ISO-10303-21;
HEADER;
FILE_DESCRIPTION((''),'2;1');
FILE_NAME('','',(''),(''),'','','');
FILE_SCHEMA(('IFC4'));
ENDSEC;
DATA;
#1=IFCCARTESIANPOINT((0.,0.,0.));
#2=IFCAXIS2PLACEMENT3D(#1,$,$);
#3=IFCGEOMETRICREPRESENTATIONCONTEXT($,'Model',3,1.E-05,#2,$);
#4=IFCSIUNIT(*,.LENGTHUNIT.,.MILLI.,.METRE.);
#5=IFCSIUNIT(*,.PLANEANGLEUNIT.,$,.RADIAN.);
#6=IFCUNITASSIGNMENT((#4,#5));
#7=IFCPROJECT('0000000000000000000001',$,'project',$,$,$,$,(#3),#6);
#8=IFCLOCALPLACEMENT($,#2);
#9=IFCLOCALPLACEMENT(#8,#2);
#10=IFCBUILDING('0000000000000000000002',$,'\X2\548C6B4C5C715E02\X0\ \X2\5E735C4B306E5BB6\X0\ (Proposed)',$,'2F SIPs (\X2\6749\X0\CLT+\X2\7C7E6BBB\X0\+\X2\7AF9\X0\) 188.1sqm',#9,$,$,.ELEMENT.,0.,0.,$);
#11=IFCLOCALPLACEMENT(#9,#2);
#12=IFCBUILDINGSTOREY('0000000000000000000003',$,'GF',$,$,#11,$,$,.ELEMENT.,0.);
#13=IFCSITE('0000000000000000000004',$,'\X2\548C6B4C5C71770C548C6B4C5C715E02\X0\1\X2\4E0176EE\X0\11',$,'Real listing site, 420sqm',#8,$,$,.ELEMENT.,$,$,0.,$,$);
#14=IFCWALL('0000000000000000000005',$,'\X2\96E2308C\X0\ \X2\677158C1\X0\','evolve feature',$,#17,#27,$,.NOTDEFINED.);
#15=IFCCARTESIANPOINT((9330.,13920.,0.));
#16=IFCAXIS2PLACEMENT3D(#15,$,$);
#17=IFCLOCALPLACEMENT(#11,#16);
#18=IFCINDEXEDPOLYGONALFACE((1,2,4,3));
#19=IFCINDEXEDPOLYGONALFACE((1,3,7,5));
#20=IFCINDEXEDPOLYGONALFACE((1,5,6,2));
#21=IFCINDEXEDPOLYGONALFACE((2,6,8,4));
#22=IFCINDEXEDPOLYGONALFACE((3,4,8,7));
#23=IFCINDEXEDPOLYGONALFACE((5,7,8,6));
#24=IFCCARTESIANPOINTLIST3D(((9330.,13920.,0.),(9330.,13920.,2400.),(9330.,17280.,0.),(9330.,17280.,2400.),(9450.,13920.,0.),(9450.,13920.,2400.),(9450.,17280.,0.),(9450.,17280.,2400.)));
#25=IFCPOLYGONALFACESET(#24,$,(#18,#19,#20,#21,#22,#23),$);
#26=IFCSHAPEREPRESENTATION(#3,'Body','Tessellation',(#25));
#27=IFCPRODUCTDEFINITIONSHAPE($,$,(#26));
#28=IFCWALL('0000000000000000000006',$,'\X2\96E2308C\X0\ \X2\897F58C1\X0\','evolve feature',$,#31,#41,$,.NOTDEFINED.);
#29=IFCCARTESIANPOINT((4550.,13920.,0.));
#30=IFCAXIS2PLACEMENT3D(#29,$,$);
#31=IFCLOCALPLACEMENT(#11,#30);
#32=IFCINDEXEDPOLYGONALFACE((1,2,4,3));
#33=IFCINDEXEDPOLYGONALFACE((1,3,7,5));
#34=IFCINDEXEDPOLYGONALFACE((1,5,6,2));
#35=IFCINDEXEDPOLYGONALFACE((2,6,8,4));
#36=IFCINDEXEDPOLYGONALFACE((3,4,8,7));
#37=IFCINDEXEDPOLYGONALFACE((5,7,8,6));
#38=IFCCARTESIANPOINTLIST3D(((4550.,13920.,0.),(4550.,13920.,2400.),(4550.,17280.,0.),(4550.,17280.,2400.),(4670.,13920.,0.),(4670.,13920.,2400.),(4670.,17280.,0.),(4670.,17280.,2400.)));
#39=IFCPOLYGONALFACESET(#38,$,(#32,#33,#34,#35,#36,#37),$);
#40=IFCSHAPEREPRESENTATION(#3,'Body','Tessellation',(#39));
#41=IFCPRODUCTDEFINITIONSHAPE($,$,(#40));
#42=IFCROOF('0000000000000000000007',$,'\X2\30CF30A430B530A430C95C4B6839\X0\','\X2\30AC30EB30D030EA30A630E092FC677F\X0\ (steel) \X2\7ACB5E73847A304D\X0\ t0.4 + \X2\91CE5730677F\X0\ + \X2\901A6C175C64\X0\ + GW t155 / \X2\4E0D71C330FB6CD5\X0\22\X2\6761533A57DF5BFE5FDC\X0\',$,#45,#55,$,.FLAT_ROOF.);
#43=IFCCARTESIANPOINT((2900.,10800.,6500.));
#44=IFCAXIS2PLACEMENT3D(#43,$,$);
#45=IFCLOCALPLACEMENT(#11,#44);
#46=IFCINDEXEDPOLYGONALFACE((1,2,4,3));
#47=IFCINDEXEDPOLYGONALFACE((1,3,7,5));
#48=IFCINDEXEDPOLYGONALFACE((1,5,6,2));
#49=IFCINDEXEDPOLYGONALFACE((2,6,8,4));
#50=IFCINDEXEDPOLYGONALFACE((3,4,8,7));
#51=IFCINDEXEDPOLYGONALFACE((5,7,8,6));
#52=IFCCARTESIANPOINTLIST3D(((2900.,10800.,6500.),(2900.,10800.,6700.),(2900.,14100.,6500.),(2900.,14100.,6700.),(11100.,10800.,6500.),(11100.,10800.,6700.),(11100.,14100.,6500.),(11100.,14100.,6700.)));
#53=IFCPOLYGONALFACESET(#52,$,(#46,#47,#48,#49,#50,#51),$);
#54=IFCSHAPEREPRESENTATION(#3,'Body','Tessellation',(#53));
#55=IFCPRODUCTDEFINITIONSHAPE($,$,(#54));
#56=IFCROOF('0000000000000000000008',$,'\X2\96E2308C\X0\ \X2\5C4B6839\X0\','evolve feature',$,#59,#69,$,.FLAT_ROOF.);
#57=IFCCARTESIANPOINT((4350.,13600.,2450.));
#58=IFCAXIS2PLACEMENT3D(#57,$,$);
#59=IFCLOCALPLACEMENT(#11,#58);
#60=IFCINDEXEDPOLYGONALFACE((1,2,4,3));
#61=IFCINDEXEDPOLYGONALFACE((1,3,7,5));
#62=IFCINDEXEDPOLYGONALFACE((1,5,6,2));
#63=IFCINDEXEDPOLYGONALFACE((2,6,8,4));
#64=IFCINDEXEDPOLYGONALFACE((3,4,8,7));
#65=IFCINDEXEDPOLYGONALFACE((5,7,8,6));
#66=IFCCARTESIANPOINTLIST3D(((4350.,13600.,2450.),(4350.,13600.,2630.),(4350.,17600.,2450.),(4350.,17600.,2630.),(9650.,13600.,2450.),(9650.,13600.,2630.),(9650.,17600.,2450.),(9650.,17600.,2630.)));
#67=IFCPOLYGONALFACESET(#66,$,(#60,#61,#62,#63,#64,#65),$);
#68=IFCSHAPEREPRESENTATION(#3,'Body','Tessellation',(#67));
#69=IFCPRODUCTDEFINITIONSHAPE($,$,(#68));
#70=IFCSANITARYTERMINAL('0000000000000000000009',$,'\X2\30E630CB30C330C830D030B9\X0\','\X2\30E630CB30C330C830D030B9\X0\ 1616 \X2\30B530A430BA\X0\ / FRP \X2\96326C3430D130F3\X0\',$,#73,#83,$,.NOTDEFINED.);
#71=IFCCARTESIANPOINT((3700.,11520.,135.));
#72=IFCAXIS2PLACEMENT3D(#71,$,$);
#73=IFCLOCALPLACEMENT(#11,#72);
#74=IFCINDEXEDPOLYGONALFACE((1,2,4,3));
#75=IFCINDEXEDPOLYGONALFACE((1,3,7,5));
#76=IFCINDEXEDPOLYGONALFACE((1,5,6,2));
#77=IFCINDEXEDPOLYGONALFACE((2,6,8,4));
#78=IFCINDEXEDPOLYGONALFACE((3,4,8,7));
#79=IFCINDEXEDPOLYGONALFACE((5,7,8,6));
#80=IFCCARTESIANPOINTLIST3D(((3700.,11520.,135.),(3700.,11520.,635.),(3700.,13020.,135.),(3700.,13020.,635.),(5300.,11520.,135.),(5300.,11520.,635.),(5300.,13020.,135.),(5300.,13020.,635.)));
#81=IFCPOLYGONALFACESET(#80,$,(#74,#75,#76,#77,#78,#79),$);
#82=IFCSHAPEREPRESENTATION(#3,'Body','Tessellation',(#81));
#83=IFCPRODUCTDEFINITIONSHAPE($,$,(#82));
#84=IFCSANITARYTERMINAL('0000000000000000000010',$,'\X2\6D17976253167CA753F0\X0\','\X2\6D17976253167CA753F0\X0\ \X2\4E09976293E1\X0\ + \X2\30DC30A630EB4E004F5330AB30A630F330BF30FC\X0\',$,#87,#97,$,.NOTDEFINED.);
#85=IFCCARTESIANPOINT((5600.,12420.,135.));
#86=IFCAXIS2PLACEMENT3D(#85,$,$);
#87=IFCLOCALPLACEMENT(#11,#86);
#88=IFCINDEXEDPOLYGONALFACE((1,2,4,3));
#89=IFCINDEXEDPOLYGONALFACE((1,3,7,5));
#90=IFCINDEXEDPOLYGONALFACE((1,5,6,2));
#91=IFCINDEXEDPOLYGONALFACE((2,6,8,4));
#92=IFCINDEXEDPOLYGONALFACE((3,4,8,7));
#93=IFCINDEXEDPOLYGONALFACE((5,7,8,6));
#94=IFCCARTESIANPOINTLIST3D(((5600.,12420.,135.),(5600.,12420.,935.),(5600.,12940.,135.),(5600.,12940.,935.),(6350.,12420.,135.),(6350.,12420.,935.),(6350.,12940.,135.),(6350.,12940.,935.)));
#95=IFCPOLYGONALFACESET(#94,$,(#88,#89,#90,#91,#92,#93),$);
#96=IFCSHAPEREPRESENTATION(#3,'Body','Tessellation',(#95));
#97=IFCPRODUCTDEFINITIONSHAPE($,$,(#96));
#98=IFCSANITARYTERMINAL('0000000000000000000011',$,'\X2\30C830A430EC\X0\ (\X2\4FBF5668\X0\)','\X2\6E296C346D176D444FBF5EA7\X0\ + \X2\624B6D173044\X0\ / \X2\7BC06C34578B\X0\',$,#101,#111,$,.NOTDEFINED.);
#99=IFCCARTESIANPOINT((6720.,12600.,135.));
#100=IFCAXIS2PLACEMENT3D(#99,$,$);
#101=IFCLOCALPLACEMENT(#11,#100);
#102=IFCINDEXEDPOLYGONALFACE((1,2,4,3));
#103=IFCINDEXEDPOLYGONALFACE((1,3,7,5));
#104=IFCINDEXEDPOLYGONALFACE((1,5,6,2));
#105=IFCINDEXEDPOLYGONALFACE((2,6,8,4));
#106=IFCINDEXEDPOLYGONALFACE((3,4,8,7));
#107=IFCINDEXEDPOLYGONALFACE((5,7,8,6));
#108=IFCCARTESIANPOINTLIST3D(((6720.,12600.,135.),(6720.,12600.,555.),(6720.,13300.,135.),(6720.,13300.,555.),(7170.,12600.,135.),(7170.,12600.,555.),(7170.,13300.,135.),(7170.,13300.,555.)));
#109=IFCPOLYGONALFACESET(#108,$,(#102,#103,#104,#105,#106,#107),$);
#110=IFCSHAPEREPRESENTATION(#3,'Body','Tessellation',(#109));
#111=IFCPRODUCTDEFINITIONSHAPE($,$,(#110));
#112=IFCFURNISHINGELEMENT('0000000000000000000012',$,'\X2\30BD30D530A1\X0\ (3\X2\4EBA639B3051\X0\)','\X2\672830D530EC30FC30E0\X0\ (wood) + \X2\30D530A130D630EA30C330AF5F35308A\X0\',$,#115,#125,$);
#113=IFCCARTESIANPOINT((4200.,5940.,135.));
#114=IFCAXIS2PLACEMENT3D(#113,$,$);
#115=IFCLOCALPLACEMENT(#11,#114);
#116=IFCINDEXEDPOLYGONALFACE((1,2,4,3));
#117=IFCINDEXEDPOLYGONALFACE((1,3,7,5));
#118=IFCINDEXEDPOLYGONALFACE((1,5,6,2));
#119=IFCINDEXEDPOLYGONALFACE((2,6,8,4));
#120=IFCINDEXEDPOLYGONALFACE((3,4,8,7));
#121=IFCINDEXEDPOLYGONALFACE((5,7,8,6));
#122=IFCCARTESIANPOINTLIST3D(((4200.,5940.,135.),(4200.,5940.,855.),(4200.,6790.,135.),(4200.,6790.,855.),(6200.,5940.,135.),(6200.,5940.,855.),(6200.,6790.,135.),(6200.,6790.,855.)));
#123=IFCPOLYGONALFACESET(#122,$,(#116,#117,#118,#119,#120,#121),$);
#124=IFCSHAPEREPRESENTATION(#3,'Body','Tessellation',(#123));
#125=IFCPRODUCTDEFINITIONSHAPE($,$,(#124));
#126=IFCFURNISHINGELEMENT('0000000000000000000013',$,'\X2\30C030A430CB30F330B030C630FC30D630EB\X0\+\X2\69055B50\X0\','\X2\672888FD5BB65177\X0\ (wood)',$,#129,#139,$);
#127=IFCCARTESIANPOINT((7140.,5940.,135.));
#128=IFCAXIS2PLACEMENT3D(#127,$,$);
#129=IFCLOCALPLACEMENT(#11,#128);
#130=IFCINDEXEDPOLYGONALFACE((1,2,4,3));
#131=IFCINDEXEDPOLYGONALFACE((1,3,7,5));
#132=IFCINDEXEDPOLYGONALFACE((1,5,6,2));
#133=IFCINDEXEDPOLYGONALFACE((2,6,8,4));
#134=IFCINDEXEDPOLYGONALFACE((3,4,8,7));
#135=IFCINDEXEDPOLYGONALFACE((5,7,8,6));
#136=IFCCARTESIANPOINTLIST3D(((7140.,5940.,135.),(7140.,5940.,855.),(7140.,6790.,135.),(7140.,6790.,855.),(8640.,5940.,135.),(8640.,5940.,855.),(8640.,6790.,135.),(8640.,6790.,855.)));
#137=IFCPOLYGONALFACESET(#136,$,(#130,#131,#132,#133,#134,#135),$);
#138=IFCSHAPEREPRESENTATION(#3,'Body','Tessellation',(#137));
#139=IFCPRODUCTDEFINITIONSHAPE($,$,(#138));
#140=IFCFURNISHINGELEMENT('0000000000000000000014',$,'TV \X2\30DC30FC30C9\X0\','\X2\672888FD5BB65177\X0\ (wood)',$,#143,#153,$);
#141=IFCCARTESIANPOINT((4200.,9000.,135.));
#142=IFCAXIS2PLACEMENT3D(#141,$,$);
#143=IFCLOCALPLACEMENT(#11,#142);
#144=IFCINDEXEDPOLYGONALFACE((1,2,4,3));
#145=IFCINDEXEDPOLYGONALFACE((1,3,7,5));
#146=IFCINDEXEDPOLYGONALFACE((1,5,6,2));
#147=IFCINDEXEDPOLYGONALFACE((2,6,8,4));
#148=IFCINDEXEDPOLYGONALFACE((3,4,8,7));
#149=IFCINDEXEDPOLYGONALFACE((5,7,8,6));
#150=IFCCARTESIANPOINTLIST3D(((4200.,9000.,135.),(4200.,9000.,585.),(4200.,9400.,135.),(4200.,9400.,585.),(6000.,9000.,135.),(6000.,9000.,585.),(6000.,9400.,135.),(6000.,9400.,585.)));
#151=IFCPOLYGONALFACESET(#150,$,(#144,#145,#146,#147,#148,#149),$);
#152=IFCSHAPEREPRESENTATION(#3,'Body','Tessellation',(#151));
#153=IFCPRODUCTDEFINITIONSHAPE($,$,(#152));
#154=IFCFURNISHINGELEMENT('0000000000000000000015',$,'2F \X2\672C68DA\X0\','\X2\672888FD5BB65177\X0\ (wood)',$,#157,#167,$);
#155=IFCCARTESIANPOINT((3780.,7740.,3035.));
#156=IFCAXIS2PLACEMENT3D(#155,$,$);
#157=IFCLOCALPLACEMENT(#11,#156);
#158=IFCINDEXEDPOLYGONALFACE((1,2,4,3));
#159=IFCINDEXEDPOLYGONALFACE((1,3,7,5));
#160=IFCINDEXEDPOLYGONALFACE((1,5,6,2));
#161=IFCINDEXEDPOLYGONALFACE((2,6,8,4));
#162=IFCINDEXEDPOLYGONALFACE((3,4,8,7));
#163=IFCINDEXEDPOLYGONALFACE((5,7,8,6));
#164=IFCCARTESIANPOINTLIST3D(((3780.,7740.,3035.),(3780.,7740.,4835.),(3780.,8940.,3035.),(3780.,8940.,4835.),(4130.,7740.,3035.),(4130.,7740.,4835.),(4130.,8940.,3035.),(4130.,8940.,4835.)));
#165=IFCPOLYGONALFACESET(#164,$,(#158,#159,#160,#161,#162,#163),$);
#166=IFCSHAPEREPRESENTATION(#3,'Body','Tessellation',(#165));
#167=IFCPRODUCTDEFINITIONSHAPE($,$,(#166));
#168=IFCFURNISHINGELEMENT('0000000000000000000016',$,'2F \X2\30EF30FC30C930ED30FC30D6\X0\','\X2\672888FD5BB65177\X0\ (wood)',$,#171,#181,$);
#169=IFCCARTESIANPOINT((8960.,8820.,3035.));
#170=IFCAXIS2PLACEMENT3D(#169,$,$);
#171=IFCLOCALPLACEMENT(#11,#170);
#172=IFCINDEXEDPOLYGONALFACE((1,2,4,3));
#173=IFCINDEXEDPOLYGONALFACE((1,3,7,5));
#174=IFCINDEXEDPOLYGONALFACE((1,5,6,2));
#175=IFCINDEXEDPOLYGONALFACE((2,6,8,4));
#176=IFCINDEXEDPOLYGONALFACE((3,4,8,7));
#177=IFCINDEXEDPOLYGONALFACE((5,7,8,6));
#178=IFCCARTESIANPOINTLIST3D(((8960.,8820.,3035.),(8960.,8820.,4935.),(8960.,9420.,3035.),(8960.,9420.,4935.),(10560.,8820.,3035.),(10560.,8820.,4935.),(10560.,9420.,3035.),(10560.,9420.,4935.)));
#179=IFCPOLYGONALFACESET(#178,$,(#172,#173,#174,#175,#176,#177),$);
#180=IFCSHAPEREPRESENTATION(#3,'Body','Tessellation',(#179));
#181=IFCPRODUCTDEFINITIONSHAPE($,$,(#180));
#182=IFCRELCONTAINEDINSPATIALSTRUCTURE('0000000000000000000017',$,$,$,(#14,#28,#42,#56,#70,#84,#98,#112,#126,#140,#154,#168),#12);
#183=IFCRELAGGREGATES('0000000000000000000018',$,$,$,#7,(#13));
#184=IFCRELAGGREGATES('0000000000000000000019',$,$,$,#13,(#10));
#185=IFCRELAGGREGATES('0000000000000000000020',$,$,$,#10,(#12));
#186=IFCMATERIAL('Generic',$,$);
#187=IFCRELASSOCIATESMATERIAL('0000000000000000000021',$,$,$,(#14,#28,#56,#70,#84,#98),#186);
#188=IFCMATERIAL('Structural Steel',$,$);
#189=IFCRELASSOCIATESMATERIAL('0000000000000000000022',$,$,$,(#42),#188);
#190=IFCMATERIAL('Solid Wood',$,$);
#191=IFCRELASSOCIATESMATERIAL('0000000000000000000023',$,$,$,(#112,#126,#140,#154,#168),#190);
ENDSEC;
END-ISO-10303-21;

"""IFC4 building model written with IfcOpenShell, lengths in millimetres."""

from ifc_helpers import new_model, si_unit, frame, frame_2d, origin, place, context, project, spatial, rectangle, extrude, material, element, save


model = new_model("IFC4")

# Units and contexts
model_context = context("Model", 3, precision=1e-05, world=origin())
ifc_project = project(units=[si_unit("LENGTHUNIT", "METRE", prefix="MILLI"), si_unit("PLANEANGLEUNIT", "RADIAN")], contexts=[model_context])

# Site, building, storey
site_placement = place(None, origin())
site = spatial("IfcSite", under=ifc_project, at=site_placement, Name="和歌山県和歌山市1丁目11", ObjectType="Real listing site, 420sqm", CompositionType="ELEMENT", RefElevation=0.0)
building_placement = place(site_placement, origin())
building = spatial("IfcBuilding", under=site, at=building_placement, Name="和歌山市 平屋の家 (Proposed)", ObjectType="2F SIPs (杉CLT+籾殻+竹) 188.1sqm", CompositionType="ELEMENT", ElevationOfRefHeight=0.0, ElevationOfTerrain=0.0)
storey_placement = place(building_placement, origin())
storey = spatial("IfcBuildingStorey", under=building, at=storey_placement, Name="GF", CompositionType="ELEMENT", Elevation=0.0)

# Shared definitions
ifc_material_1 = material(Name="Generic")

# Shared definitions
ifc_material_2 = material(Name="Solid Wood")

# Walls
wall_1_placement = place(storey_placement, frame((9330.0, 13920.0, 0.0)))
element("IfcWall", 1, at=wall_1_placement, inside=storey, material=ifc_material_1, Name="離れ 東壁", Description="evolve feature", PredefinedType="NOTDEFINED", context=model_context, shape_type="SweptSolid", body=[
    extrude(rectangle(XDim=120.0, YDim=3360.0, at=frame_2d((60.0, 1680.0))), frame((9330.0, 13920.0, 0.0)), (0.0, 0.0, 1.0), 2400.0),
])
wall_2_placement = place(storey_placement, frame((4550.0, 13920.0, 0.0)))
element("IfcWall", 2, at=wall_2_placement, inside=storey, material=ifc_material_1, Name="離れ 西壁", Description="evolve feature", PredefinedType="NOTDEFINED", context=model_context, shape_type="SweptSolid", body=[
    extrude(rectangle(XDim=120.0, YDim=3360.0, at=frame_2d((60.0, 1680.0))), frame((4550.0, 13920.0, 0.0)), (0.0, 0.0, 1.0), 2400.0),
])

# Roofs
ifc_material_3 = material(Name="Structural Steel")
roof_1_placement = place(storey_placement, frame((2900.0, 10800.0, 6500.0)))
element("IfcRoof", 3, at=roof_1_placement, inside=storey, material=ifc_material_3, Name="ハイサイド屋根", Description="ガルバリウム鋼板 (steel) 立平葺き t0.4 + 野地板 + 通気層 + GW t155 / 不燃・法22条区域対応", PredefinedType="FLAT_ROOF", context=model_context, shape_type="SweptSolid", body=[
    extrude(rectangle(XDim=8200.0, YDim=3300.0, at=frame_2d((4100.0, 1650.0))), frame((2900.0, 10800.0, 6500.0)), (0.0, 0.0, 1.0), 200.0),
])
roof_2_placement = place(storey_placement, frame((4350.0, 13600.0, 2450.0)))
element("IfcRoof", 4, at=roof_2_placement, inside=storey, material=ifc_material_1, Name="離れ 屋根", Description="evolve feature", PredefinedType="FLAT_ROOF", context=model_context, shape_type="SweptSolid", body=[
    extrude(rectangle(XDim=5300.0, YDim=4000.0, at=frame_2d((2650.0, 2000.0))), frame((4350.0, 13600.0, 2450.0)), (0.0, 0.0, 1.0), 180.0),
])

# Sanitary terminals
sanitary_terminal_1_placement = place(storey_placement, frame((3700.0, 11520.0, 135.0)))
element("IfcSanitaryTerminal", 5, at=sanitary_terminal_1_placement, inside=storey, material=ifc_material_1, Name="ユニットバス", Description="ユニットバス 1616 サイズ / FRP 防水パン", PredefinedType="NOTDEFINED", context=model_context, shape_type="SweptSolid", body=[
    extrude(rectangle(XDim=1600.0, YDim=1500.0, at=frame_2d((800.0, 750.0))), frame((3700.0, 11520.0, 135.0)), (0.0, 0.0, 1.0), 500.0),
])
sanitary_terminal_2_placement = place(storey_placement, frame((5600.0, 12420.0, 135.0)))
element("IfcSanitaryTerminal", 6, at=sanitary_terminal_2_placement, inside=storey, material=ifc_material_1, Name="洗面化粧台", Description="洗面化粧台 三面鏡 + ボウル一体カウンター", PredefinedType="NOTDEFINED", context=model_context, shape_type="SweptSolid", body=[
    extrude(rectangle(XDim=750.0, YDim=520.0, at=frame_2d((375.0, 260.0))), frame((5600.0, 12420.0, 135.0)), (0.0, 0.0, 1.0), 800.0),
])
sanitary_terminal_3_placement = place(storey_placement, frame((6720.0, 12600.0, 135.0)))
element("IfcSanitaryTerminal", 7, at=sanitary_terminal_3_placement, inside=storey, material=ifc_material_1, Name="トイレ (便器)", Description="温水洗浄便座 + 手洗い / 節水型", PredefinedType="NOTDEFINED", context=model_context, shape_type="SweptSolid", body=[
    extrude(rectangle(XDim=450.0, YDim=700.0, at=frame_2d((225.0, 350.0))), frame((6720.0, 12600.0, 135.0)), (0.0, 0.0, 1.0), 420.0),
])

# Furnishing elements
furnishing_1_placement = place(storey_placement, frame((4200.0, 5940.0, 135.0)))
element("IfcFurnishingElement", 8, at=furnishing_1_placement, inside=storey, material=ifc_material_2, Name="ソファ (3人掛け)", Description="木フレーム (wood) + ファブリック張り", context=model_context, shape_type="SweptSolid", body=[
    extrude(rectangle(XDim=2000.0, YDim=850.0, at=frame_2d((1000.0, 425.0))), frame((4200.0, 5940.0, 135.0)), (0.0, 0.0, 1.0), 720.0),
])
furnishing_2_placement = place(storey_placement, frame((7140.0, 5940.0, 135.0)))
element("IfcFurnishingElement", 9, at=furnishing_2_placement, inside=storey, material=ifc_material_2, Name="ダイニングテーブル+椅子", Description="木製家具 (wood)", context=model_context, shape_type="SweptSolid", body=[
    extrude(rectangle(XDim=1500.0, YDim=850.0, at=frame_2d((750.0, 425.0))), frame((7140.0, 5940.0, 135.0)), (0.0, 0.0, 1.0), 720.0),
])
furnishing_3_placement = place(storey_placement, frame((4200.0, 9000.0, 135.0)))
element("IfcFurnishingElement", 10, at=furnishing_3_placement, inside=storey, material=ifc_material_2, Name="TV ボード", Description="木製家具 (wood)", context=model_context, shape_type="SweptSolid", body=[
    extrude(rectangle(XDim=1800.0, YDim=400.0, at=frame_2d((900.0, 200.0))), frame((4200.0, 9000.0, 135.0)), (0.0, 0.0, 1.0), 450.0),
])
furnishing_4_placement = place(storey_placement, frame((3780.0, 7740.0, 3035.0)))
element("IfcFurnishingElement", 11, at=furnishing_4_placement, inside=storey, material=ifc_material_2, Name="2F 本棚", Description="木製家具 (wood)", context=model_context, shape_type="SweptSolid", body=[
    extrude(rectangle(XDim=350.0, YDim=1200.0, at=frame_2d((175.0, 600.0))), frame((3780.0, 7740.0, 3035.0)), (0.0, 0.0, 1.0), 1800.0),
])
furnishing_5_placement = place(storey_placement, frame((8960.0, 8820.0, 3035.0)))
element("IfcFurnishingElement", 12, at=furnishing_5_placement, inside=storey, material=ifc_material_2, Name="2F ワードローブ", Description="木製家具 (wood)", context=model_context, shape_type="SweptSolid", body=[
    extrude(rectangle(XDim=1600.0, YDim=600.0, at=frame_2d((800.0, 300.0))), frame((8960.0, 8820.0, 3035.0)), (0.0, 0.0, 1.0), 1900.0),
])

save(model, "model.ifc")
